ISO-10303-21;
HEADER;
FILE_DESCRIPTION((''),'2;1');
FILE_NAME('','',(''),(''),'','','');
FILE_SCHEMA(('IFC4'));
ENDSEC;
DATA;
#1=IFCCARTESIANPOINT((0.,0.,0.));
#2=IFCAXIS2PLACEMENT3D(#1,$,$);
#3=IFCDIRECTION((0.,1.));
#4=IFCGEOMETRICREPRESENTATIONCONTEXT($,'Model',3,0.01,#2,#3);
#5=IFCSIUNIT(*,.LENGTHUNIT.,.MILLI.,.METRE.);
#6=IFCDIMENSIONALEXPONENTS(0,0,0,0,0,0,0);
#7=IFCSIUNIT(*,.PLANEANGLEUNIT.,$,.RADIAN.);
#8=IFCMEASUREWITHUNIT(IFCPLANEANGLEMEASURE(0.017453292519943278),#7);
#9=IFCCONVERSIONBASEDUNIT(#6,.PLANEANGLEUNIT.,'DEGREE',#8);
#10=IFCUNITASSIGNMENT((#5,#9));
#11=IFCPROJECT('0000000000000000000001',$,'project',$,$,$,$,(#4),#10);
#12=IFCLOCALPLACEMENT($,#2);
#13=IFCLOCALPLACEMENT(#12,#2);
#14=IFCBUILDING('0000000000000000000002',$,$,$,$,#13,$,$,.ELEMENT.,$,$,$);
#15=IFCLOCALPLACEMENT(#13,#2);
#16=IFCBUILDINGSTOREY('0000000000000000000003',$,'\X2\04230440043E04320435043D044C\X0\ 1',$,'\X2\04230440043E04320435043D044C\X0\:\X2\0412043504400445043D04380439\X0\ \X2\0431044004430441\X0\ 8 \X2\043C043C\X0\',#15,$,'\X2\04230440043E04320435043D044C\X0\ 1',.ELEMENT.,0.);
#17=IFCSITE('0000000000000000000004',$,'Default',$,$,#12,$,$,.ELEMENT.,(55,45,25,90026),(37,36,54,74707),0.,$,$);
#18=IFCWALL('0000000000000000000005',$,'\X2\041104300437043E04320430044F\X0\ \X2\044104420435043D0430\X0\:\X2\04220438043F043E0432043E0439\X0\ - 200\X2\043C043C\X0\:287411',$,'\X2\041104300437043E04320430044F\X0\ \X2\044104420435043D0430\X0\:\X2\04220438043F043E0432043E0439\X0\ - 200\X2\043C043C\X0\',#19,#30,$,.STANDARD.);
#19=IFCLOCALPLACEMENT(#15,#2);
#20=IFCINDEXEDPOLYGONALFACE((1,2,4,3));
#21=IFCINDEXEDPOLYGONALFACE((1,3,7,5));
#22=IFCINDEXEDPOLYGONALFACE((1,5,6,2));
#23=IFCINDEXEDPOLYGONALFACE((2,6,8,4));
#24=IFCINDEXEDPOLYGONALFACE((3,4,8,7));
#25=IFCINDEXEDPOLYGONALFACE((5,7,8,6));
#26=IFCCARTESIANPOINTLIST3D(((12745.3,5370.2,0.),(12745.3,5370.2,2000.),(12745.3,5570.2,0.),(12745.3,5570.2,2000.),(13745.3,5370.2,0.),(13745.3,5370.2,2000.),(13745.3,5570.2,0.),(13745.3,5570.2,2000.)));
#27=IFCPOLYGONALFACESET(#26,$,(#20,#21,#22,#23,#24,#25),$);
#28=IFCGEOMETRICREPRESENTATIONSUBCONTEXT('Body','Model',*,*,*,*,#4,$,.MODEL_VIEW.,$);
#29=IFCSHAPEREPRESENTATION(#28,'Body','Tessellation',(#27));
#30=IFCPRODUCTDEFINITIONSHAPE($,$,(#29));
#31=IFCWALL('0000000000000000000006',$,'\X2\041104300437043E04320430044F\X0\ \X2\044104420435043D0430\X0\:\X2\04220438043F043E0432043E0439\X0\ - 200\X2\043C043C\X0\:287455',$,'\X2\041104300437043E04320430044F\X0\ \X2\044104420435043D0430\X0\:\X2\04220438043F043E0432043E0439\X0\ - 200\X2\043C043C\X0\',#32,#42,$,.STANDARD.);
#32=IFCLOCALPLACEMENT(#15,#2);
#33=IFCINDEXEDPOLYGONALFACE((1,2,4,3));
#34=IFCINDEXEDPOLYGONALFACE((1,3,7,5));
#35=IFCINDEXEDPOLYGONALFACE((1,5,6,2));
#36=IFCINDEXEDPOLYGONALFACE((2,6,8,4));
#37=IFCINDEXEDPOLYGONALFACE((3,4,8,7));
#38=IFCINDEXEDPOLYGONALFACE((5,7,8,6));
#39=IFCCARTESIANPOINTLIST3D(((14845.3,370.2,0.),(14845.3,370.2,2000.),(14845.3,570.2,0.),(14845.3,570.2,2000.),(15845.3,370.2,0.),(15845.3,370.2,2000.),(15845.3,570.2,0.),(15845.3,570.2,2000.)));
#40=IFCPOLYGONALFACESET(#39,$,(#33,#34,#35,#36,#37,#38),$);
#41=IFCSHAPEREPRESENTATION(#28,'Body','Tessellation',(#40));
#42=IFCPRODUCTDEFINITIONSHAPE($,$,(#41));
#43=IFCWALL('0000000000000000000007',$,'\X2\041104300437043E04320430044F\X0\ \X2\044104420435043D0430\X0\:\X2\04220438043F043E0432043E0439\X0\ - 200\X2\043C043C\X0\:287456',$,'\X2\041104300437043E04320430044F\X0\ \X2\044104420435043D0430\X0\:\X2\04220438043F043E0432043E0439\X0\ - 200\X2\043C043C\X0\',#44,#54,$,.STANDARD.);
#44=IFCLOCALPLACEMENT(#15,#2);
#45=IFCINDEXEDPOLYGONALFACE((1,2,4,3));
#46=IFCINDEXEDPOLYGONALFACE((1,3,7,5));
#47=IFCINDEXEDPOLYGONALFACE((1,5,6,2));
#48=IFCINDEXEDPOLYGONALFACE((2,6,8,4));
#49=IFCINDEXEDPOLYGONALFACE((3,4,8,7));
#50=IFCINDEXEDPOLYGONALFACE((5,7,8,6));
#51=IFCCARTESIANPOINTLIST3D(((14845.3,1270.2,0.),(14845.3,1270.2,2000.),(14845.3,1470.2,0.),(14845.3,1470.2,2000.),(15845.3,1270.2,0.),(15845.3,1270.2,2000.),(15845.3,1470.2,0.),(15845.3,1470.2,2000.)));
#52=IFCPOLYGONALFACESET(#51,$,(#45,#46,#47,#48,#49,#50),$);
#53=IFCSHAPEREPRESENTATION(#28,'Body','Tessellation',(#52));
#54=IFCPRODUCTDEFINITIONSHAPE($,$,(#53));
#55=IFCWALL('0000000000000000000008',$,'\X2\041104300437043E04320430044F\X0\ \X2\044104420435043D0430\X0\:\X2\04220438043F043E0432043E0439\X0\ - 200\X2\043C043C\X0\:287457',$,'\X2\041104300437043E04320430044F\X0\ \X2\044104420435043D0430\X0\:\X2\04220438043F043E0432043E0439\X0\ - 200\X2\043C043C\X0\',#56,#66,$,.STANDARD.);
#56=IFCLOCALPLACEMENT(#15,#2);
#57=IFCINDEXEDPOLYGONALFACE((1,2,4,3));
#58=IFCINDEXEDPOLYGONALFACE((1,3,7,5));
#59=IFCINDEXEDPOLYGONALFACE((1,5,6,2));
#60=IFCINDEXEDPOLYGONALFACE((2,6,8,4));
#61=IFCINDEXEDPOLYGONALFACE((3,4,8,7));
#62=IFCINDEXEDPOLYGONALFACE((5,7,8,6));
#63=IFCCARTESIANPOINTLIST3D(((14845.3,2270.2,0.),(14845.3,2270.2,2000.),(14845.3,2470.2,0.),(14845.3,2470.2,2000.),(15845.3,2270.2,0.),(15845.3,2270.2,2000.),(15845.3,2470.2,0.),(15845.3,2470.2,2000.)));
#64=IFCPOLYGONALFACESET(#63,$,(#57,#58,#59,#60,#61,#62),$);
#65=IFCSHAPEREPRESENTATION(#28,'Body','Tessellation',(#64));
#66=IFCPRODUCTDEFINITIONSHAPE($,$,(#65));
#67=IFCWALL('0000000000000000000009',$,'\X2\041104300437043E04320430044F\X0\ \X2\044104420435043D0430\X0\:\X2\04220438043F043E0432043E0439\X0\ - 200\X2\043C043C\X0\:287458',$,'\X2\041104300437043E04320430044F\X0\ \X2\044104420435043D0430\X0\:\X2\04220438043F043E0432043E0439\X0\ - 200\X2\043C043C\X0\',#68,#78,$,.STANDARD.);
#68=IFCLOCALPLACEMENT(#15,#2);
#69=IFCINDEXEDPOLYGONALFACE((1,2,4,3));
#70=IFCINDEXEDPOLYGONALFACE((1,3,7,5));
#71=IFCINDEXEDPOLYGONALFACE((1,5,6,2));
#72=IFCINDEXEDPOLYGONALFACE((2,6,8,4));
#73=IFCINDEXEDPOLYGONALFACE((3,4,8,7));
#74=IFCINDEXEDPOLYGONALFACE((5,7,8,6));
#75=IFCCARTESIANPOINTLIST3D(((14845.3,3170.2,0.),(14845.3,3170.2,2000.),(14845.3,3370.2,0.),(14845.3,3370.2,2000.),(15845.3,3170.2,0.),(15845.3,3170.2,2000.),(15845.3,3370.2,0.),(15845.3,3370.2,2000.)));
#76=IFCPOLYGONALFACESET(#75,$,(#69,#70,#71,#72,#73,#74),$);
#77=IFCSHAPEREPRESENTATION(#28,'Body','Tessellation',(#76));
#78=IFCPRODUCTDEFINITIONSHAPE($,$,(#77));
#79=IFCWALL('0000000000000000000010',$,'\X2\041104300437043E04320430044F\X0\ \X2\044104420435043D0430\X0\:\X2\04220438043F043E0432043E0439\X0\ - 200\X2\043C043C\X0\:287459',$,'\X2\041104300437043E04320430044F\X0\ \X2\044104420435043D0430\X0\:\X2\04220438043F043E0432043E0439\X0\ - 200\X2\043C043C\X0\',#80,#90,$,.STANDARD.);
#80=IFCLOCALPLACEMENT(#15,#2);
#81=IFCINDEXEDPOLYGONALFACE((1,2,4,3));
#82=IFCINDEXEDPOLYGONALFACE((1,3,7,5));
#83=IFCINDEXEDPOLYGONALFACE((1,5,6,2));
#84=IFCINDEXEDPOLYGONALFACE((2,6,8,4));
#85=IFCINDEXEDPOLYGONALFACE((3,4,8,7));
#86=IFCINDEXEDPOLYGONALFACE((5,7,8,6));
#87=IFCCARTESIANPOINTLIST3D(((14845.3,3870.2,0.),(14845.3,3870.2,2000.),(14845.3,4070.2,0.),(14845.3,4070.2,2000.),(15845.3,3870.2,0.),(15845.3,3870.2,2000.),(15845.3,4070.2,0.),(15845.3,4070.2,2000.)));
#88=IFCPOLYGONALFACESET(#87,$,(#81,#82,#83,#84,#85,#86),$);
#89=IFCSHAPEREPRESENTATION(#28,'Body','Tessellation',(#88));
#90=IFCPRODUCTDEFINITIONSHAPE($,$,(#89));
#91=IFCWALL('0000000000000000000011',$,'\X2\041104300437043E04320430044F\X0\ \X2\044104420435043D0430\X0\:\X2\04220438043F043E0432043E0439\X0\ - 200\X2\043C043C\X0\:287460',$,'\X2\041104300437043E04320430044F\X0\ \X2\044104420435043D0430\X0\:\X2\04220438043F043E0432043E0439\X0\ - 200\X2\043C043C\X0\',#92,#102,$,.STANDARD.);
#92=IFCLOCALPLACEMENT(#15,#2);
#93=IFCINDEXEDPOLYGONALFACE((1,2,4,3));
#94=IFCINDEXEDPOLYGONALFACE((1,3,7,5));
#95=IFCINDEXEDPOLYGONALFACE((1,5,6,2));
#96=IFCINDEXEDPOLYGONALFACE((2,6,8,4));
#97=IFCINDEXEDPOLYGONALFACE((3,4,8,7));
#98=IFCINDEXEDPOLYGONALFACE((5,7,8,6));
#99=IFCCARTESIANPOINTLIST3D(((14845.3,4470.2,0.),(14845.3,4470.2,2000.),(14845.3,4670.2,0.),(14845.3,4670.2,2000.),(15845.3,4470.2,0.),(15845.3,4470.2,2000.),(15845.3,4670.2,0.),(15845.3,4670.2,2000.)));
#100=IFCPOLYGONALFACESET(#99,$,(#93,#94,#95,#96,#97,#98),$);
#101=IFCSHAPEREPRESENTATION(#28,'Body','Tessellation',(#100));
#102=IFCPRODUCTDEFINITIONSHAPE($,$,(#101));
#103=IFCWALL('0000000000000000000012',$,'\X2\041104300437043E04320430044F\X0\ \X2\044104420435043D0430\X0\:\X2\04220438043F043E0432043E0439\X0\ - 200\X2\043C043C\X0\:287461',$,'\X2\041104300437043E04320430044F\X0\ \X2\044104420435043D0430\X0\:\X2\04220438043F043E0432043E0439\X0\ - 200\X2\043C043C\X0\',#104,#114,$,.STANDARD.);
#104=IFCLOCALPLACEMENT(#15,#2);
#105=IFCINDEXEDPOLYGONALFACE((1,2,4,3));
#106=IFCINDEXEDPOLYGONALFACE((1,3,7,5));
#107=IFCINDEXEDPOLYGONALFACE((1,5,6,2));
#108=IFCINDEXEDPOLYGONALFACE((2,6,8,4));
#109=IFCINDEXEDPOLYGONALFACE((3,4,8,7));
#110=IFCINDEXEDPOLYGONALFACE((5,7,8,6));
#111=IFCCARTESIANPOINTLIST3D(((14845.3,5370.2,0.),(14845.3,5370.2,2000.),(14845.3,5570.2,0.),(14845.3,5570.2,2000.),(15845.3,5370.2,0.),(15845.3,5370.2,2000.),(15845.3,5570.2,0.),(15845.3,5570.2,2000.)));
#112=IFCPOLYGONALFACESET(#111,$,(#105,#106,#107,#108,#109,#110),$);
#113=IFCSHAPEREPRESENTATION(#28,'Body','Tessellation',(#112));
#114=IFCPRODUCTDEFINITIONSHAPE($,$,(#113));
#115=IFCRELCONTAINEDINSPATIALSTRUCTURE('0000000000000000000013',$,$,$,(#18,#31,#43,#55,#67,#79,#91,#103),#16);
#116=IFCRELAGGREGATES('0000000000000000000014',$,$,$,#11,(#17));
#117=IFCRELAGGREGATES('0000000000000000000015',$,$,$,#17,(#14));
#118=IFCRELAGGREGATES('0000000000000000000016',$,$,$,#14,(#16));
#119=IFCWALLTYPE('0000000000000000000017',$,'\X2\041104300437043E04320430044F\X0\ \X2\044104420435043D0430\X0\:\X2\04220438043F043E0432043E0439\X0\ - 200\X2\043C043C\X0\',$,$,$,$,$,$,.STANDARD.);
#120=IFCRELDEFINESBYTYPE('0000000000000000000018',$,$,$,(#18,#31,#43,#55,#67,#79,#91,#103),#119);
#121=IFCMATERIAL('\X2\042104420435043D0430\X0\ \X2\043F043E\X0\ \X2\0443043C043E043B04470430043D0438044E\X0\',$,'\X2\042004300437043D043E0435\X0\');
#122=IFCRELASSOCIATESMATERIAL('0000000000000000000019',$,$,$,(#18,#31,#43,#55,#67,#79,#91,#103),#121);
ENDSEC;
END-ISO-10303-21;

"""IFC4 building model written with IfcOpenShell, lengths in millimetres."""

from ifc_helpers import new_model, entity, si_unit, converted_unit, direction, frame, origin, place, context, subcontext, project, spatial, indexed_curve, outline, extrude, material, type_object, element, save


model = new_model("IFC4")

# Units and contexts
model_context = context("Model", 3, precision=0.01, world=origin(), true_north=direction((0.0, 1.0)))
body_context = subcontext(model_context, "Body", "Model", "MODEL_VIEW")
ifc_project = project(units=[si_unit("LENGTHUNIT", "METRE", prefix="MILLI"), converted_unit("PLANEANGLEUNIT", "DEGREE", entity("IfcPlaneAngleMeasure", 0.017453292519943278), si_unit("PLANEANGLEUNIT", "RADIAN"), dimensions=[0, 0, 0, 0, 0, 0, 0])], contexts=[model_context])

# Site, building, storey
site_placement = place(None, origin())
site = spatial("IfcSite", under=ifc_project, at=site_placement, Name="Default", CompositionType="ELEMENT", RefLatitude=(55, 45, 25, 90026), RefLongitude=(37, 36, 54, 74707), RefElevation=0.0)
building_placement = place(site_placement, origin())
building = spatial("IfcBuilding", under=site, at=building_placement, CompositionType="ELEMENT")
storey_placement = place(building_placement, origin())
storey = spatial("IfcBuildingStorey", under=building, at=storey_placement, Name="Уровень 1", ObjectType="Уровень:Верхний брус 8 мм", LongName="Уровень 1", CompositionType="ELEMENT", Elevation=0.0)

# Walls
ifc_material = material(Name="Стена по умолчанию", Category="Разное")
wall_type = type_object("IfcWallType", Name="Базовая стена:Типовой - 200мм", PredefinedType="STANDARD")
for number, where, name in (
    (1, (12745.3, 5470.2, 0.0), "Базовая стена:Типовой - 200мм:287411"),
):
    element("IfcWall", number, at=place(storey_placement, frame(where)), inside=storey, type_object=wall_type, material=ifc_material, Name=name, ObjectType="Базовая стена:Типовой - 200мм", PredefinedType="STANDARD", context=body_context, shape_type="SweptSolid", body=[
        extrude(outline(indexed_curve([(1000.0, 100.0), (0.0, 100.0), (0.0, -100.0), (1000.0, -100.0), (1000.0, 100.0)], self_intersect=False)), origin(), (0.0, 0.0, 1.0), 2000.0),
    ])
wall_1_placement = place(storey_placement, frame((14845.3, 470.2, 0.0)))
element("IfcWall", 2, at=wall_1_placement, inside=storey, type_object=wall_type, material=ifc_material, Name="Базовая стена:Типовой - 200мм:287455", ObjectType="Базовая стена:Типовой - 200мм", PredefinedType="STANDARD", context=body_context, shape_type="SweptSolid", body=[
    extrude(outline(indexed_curve([(1000.0, 100.0), (0.0, 100.0), (0.0, -100.0), (1000.0, -100.0), (1000.0, 100.0)], self_intersect=False)), origin(), (0.0, 0.0, 1.0), 2000.0),
])
wall_2_placement = place(storey_placement, frame((14845.3, 1370.2, 0.0)))
element("IfcWall", 3, at=wall_2_placement, inside=storey, type_object=wall_type, material=ifc_material, Name="Базовая стена:Типовой - 200мм:287456", ObjectType="Базовая стена:Типовой - 200мм", PredefinedType="STANDARD", context=body_context, shape_type="SweptSolid", body=[
    extrude(outline(indexed_curve([(1000.0, 100.0), (0.0, 100.0), (0.0, -100.0), (1000.0, -100.0), (1000.0, 100.0)], self_intersect=False)), origin(), (0.0, 0.0, 1.0), 2000.0),
])
wall_3_placement = place(storey_placement, frame((14845.3, 2370.2, 0.0)))
element("IfcWall", 4, at=wall_3_placement, inside=storey, type_object=wall_type, material=ifc_material, Name="Базовая стена:Типовой - 200мм:287457", ObjectType="Базовая стена:Типовой - 200мм", PredefinedType="STANDARD", context=body_context, shape_type="SweptSolid", body=[
    extrude(outline(indexed_curve([(1000.0, 100.0), (0.0, 100.0), (0.0, -100.0), (1000.0, -100.0), (1000.0, 100.0)], self_intersect=False)), origin(), (0.0, 0.0, 1.0), 2000.0),
])
wall_4_placement = place(storey_placement, frame((14845.3, 3270.2, 0.0)))
element("IfcWall", 5, at=wall_4_placement, inside=storey, type_object=wall_type, material=ifc_material, Name="Базовая стена:Типовой - 200мм:287458", ObjectType="Базовая стена:Типовой - 200мм", PredefinedType="STANDARD", context=body_context, shape_type="SweptSolid", body=[
    extrude(outline(indexed_curve([(1000.0, 100.0), (0.0, 100.0), (0.0, -100.0), (1000.0, -100.0), (1000.0, 100.0)], self_intersect=False)), origin(), (0.0, 0.0, 1.0), 2000.0),
])
wall_5_placement = place(storey_placement, frame((14845.3, 3970.2, 0.0)))
element("IfcWall", 6, at=wall_5_placement, inside=storey, type_object=wall_type, material=ifc_material, Name="Базовая стена:Типовой - 200мм:287459", ObjectType="Базовая стена:Типовой - 200мм", PredefinedType="STANDARD", context=body_context, shape_type="SweptSolid", body=[
    extrude(outline(indexed_curve([(1000.0, 100.0), (0.0, 100.0), (0.0, -100.0), (1000.0, -100.0), (1000.0, 100.0)], self_intersect=False)), origin(), (0.0, 0.0, 1.0), 2000.0),
])
wall_6_placement = place(storey_placement, frame((14845.3, 4570.2, 0.0)))
element("IfcWall", 7, at=wall_6_placement, inside=storey, type_object=wall_type, material=ifc_material, Name="Базовая стена:Типовой - 200мм:287460", ObjectType="Базовая стена:Типовой - 200мм", PredefinedType="STANDARD", context=body_context, shape_type="SweptSolid", body=[
    extrude(outline(indexed_curve([(1000.0, 100.0), (0.0, 100.0), (0.0, -100.0), (1000.0, -100.0), (1000.0, 100.0)], self_intersect=False)), origin(), (0.0, 0.0, 1.0), 2000.0),
])
wall_7_placement = place(storey_placement, frame((14845.3, 5470.2, 0.0)))
element("IfcWall", 8, at=wall_7_placement, inside=storey, type_object=wall_type, material=ifc_material, Name="Базовая стена:Типовой - 200мм:287461", ObjectType="Базовая стена:Типовой - 200мм", PredefinedType="STANDARD", context=body_context, shape_type="SweptSolid", body=[
    extrude(outline(indexed_curve([(1000.0, 100.0), (0.0, 100.0), (0.0, -100.0), (1000.0, -100.0), (1000.0, 100.0)], self_intersect=False)), origin(), (0.0, 0.0, 1.0), 2000.0),
])

save(model, "model.ifc")
